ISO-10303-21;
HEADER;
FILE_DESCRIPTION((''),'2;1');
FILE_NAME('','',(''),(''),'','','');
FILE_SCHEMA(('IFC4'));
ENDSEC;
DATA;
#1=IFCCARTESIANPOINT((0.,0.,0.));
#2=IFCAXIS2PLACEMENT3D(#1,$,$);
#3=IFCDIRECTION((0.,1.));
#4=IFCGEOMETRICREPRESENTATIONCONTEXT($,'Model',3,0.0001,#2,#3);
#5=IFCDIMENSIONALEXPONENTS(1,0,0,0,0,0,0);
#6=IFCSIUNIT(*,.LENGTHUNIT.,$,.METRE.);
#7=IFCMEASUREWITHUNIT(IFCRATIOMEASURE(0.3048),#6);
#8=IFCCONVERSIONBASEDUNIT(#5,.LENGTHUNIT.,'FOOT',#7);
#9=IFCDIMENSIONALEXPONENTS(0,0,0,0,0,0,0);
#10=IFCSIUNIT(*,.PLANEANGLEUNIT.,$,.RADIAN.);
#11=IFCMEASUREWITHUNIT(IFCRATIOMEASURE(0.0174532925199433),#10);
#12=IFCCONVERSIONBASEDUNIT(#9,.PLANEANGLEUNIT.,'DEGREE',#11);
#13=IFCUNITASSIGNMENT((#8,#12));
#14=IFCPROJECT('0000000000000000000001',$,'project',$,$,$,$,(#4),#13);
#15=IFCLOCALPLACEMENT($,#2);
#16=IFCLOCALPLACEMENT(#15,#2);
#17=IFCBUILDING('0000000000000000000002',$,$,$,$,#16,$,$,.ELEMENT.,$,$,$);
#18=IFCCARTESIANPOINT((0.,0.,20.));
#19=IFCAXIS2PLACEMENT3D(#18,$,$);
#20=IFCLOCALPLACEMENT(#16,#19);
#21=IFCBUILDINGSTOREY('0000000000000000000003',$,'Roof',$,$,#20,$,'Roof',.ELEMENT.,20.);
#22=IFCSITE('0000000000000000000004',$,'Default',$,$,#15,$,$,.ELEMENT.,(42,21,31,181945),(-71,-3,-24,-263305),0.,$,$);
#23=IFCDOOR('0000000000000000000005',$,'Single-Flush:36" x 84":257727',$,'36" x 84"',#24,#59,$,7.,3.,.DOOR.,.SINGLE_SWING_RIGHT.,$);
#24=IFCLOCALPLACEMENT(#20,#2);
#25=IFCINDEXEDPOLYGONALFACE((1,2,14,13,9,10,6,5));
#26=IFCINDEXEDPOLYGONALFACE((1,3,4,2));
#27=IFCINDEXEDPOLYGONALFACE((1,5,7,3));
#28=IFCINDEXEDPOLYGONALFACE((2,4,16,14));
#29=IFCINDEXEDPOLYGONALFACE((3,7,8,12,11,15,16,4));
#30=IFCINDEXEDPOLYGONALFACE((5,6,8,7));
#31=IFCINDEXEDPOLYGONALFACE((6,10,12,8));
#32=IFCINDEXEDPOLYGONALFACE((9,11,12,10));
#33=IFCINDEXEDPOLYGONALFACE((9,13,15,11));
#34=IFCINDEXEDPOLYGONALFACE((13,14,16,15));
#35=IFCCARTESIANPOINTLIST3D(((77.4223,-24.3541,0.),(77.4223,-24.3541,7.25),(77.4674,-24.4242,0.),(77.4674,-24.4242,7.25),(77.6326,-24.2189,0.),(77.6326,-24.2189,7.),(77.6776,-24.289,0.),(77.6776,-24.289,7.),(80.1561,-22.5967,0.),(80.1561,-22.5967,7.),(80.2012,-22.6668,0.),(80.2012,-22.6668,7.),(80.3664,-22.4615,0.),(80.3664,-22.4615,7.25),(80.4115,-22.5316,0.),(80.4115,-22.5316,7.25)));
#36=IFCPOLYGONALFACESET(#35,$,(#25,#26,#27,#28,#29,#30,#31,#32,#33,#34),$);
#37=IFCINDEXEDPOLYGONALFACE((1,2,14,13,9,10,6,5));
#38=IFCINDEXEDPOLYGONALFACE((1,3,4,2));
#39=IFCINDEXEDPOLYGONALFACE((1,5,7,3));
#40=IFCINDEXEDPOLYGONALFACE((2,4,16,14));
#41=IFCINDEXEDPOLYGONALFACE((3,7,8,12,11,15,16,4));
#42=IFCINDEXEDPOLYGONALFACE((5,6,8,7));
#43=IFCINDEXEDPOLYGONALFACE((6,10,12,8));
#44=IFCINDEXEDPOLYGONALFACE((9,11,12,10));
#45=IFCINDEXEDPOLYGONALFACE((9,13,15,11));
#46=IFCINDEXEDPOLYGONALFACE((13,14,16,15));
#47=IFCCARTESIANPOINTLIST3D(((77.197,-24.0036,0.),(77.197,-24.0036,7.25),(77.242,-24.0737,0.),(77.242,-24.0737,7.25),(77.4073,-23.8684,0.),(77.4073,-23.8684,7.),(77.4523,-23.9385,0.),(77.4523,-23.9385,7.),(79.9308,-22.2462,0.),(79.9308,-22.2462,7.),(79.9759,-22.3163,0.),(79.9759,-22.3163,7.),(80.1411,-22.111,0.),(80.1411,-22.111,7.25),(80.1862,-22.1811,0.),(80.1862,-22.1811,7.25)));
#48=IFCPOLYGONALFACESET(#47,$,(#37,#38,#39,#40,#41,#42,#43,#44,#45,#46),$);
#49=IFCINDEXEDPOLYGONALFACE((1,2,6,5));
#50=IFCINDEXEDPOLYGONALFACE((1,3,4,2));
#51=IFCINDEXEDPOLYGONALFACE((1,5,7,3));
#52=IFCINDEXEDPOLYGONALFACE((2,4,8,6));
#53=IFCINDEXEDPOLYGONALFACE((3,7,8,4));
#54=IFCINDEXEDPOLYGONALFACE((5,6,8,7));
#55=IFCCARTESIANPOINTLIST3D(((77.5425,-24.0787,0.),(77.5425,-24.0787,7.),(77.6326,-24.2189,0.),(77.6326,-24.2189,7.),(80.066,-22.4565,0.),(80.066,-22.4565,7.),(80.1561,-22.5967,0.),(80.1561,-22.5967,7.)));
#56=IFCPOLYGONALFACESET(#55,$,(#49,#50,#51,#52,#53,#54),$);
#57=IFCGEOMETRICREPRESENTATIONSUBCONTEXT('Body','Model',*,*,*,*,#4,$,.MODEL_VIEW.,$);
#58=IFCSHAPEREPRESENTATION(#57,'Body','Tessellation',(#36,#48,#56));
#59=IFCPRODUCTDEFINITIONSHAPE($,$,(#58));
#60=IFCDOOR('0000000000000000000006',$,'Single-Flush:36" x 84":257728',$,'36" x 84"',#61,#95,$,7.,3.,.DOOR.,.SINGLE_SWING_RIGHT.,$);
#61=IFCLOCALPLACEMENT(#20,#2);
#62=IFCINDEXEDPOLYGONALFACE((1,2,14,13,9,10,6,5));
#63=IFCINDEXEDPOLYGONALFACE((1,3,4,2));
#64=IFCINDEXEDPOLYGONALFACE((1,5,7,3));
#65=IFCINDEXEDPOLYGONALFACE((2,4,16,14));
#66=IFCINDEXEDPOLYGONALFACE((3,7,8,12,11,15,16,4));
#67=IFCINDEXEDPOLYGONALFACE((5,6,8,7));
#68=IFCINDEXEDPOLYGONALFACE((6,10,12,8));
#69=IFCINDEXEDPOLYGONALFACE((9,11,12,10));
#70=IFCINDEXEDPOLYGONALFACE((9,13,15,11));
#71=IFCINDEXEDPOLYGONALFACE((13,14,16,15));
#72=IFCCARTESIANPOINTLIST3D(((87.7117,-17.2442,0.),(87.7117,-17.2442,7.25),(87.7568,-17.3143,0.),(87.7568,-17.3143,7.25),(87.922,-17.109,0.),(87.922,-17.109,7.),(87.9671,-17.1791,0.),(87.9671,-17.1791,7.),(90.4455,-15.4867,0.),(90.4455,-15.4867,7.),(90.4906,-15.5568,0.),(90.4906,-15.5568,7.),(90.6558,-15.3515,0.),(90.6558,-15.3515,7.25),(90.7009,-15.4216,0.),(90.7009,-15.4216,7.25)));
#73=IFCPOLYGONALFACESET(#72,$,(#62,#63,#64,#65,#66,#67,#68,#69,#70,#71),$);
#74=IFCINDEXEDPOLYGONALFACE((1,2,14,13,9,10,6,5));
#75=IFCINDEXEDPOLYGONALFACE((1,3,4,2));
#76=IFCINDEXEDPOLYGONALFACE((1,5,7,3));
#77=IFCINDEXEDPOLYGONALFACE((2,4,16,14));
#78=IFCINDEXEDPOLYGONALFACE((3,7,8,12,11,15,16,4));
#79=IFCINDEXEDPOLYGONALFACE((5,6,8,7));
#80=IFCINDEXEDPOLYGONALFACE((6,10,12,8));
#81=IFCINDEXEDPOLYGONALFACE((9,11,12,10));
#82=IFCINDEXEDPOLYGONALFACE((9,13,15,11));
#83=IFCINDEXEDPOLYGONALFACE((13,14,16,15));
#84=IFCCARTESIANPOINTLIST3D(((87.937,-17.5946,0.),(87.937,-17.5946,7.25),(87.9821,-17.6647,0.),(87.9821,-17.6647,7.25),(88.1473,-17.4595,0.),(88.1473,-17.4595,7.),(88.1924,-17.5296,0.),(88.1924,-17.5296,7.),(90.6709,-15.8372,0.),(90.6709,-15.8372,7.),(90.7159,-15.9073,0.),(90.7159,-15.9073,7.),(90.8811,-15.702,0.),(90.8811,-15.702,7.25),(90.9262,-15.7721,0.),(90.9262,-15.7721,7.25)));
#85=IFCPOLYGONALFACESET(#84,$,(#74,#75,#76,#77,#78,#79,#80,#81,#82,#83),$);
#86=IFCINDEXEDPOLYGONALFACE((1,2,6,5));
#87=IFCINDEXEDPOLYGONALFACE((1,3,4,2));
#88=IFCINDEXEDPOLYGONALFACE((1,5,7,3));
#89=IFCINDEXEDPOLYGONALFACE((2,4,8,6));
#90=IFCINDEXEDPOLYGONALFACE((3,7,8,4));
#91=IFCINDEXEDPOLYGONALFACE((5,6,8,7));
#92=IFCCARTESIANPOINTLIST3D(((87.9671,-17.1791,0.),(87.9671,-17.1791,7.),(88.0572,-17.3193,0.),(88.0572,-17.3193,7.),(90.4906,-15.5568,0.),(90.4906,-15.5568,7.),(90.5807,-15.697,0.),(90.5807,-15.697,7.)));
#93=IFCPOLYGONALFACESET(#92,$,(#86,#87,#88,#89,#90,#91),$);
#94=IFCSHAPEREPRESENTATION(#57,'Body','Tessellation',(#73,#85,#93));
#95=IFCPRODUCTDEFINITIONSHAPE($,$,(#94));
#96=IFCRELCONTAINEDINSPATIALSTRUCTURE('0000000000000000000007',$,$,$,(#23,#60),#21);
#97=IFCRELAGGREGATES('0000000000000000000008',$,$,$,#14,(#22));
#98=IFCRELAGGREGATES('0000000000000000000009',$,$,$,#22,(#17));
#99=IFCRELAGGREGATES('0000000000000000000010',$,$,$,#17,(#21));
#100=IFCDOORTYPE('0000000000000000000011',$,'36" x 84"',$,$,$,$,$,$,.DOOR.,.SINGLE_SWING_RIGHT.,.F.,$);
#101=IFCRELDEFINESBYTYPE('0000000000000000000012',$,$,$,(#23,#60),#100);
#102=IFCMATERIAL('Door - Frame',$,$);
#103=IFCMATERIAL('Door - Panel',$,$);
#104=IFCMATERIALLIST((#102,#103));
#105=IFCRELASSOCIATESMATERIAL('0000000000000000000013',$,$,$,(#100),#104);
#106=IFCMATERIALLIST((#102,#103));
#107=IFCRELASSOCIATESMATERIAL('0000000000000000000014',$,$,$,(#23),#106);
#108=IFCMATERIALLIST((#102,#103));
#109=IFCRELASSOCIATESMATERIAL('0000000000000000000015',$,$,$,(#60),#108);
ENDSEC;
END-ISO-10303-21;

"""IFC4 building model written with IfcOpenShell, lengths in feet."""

from ifc_helpers import new_model, entity, si_unit, converted_unit, direction, frame, frame_2d, origin, place, context, subcontext, project, spatial, polyline, rectangle, outline, extrude, source, transform, mapped, material, material_list, type_object, type_shapes, element, save


model = new_model("IFC4")

# Units and contexts
model_context = context("Model", 3, precision=0.0001, world=origin(), true_north=direction((0.0, 1.0)))
body_context = subcontext(model_context, "Body", "Model", "MODEL_VIEW")
ifc_project = project(units=[converted_unit("LENGTHUNIT", "FOOT", entity("IfcRatioMeasure", 0.3048), si_unit("LENGTHUNIT", "METRE"), dimensions=[1, 0, 0, 0, 0, 0, 0]), converted_unit("PLANEANGLEUNIT", "DEGREE", entity("IfcRatioMeasure", 0.0174532925199433), si_unit("PLANEANGLEUNIT", "RADIAN"), dimensions=[0, 0, 0, 0, 0, 0, 0])], contexts=[model_context])

# Site, building, storey
site_placement = place(None, origin())
site = spatial("IfcSite", under=ifc_project, at=site_placement, Name="Default", CompositionType="ELEMENT", RefLatitude=(42, 21, 31, 181945), RefLongitude=(-71, -3, -24, -263305), RefElevation=0.0)
building_placement = place(site_placement, origin())
building = spatial("IfcBuilding", under=site, at=building_placement, CompositionType="ELEMENT")
storey_placement = place(building_placement, frame((0.0, 0.0, 20.0)))
storey = spatial("IfcBuildingStorey", under=building, at=storey_placement, Name="Roof", LongName="Roof", CompositionType="ELEMENT", Elevation=20.0)

# Doors
ifc_material_1 = material(Name="Door - Frame")
ifc_material_2 = material(Name="Door - Panel")
ifc_material_list_1 = material_list([ifc_material_1, ifc_material_2])
ifc_material_list_2 = material_list([ifc_material_1, ifc_material_2])
door_type = type_object("IfcDoorType", Name="36\" x 84\"", OperationType="SINGLE_SWING_RIGHT", ParameterTakesPrecedence=False, PredefinedType="DOOR", material=ifc_material_list_2)
shared_shape = source(origin(), body_context, "Body", "SweptSolid", [
    extrude(outline(polyline([(-1.75, -3.6875), (1.75, -3.6875), (1.75, 3.5625), (1.5, 3.5625), (1.5, -3.4375), (-1.5, -3.4375), (-1.5, 3.5625), (-1.75, 3.5625), (-1.75, -3.6875)])), frame((1.5, 0.3333, 3.5625), z_axis=(0.0, 1.0, 0.0), x_axis=(1.0, 0.0, 0.0)), (0.0, 0.0, 1.0), 0.0833),
    extrude(outline(polyline([(-3.6875, -1.75), (3.5625, -1.75), (3.5625, -1.5), (-3.4375, -1.5), (-3.4375, 1.5), (3.5625, 1.5), (3.5625, 1.75), (-3.6875, 1.75), (-3.6875, -1.75)])), frame((1.5, -0.0833, 3.5625), z_axis=(0.0, 1.0, 0.0), x_axis=(0.0, 0.0, -1.0)), (0.0, 0.0, 1.0), 0.0833),
    extrude(rectangle(XDim=0.1667, YDim=3.0, at=frame_2d((0.0, 0.0), x_axis=(1.0, 0.0))), frame((1.5, 0.25, 0.0), z_axis=(0.0, 0.0, 1.0), x_axis=(0.0, 1.0, 0.0)), (0.0, 0.0, 1.0), 7.0),
])
type_shapes(door_type, [shared_shape])
placement_1 = place(storey_placement, frame((103.9574, -7.0977, 0.0), z_axis=(0.0, 0.0, 1.0), x_axis=(-0.841178, -0.540758, 0.0)))
placement_2 = place(placement_1, frame((28.4023, -0.1667, 0.0)))
door_1_placement = place(placement_2, origin())
element("IfcDoor", 1, at=door_1_placement, inside=storey, type_object=door_type, material=ifc_material_list_1, Name="Single-Flush:36\" x 84\":257727", ObjectType="36\" x 84\"", OperationType="SINGLE_SWING_RIGHT", OverallHeight=7.0, OverallWidth=3.0, PredefinedType="DOOR", context=body_context, shape_type="MappedRepresentation", body=[
    mapped(shared_shape, transform((0.0, 0.0, 0.0), scale=1.0)),
])
ifc_material_list_3 = material_list([ifc_material_1, ifc_material_2])
placement_3 = place(placement_1, frame((18.9023, 0.1667, 0.0)))
door_2_placement = place(placement_3, frame((0.0, 0.0, 0.0), z_axis=(0.0, 0.0, 1.0), x_axis=(-1.0, 0.0, 0.0)))
element("IfcDoor", 2, at=door_2_placement, inside=storey, type_object=door_type, material=ifc_material_list_3, Name="Single-Flush:36\" x 84\":257728", ObjectType="36\" x 84\"", OperationType="SINGLE_SWING_RIGHT", OverallHeight=7.0, OverallWidth=3.0, PredefinedType="DOOR", context=body_context, shape_type="MappedRepresentation", body=[
    mapped(shared_shape, transform((0.0, 0.0, 0.0), scale=1.0)),
])

save(model, "model.ifc")
